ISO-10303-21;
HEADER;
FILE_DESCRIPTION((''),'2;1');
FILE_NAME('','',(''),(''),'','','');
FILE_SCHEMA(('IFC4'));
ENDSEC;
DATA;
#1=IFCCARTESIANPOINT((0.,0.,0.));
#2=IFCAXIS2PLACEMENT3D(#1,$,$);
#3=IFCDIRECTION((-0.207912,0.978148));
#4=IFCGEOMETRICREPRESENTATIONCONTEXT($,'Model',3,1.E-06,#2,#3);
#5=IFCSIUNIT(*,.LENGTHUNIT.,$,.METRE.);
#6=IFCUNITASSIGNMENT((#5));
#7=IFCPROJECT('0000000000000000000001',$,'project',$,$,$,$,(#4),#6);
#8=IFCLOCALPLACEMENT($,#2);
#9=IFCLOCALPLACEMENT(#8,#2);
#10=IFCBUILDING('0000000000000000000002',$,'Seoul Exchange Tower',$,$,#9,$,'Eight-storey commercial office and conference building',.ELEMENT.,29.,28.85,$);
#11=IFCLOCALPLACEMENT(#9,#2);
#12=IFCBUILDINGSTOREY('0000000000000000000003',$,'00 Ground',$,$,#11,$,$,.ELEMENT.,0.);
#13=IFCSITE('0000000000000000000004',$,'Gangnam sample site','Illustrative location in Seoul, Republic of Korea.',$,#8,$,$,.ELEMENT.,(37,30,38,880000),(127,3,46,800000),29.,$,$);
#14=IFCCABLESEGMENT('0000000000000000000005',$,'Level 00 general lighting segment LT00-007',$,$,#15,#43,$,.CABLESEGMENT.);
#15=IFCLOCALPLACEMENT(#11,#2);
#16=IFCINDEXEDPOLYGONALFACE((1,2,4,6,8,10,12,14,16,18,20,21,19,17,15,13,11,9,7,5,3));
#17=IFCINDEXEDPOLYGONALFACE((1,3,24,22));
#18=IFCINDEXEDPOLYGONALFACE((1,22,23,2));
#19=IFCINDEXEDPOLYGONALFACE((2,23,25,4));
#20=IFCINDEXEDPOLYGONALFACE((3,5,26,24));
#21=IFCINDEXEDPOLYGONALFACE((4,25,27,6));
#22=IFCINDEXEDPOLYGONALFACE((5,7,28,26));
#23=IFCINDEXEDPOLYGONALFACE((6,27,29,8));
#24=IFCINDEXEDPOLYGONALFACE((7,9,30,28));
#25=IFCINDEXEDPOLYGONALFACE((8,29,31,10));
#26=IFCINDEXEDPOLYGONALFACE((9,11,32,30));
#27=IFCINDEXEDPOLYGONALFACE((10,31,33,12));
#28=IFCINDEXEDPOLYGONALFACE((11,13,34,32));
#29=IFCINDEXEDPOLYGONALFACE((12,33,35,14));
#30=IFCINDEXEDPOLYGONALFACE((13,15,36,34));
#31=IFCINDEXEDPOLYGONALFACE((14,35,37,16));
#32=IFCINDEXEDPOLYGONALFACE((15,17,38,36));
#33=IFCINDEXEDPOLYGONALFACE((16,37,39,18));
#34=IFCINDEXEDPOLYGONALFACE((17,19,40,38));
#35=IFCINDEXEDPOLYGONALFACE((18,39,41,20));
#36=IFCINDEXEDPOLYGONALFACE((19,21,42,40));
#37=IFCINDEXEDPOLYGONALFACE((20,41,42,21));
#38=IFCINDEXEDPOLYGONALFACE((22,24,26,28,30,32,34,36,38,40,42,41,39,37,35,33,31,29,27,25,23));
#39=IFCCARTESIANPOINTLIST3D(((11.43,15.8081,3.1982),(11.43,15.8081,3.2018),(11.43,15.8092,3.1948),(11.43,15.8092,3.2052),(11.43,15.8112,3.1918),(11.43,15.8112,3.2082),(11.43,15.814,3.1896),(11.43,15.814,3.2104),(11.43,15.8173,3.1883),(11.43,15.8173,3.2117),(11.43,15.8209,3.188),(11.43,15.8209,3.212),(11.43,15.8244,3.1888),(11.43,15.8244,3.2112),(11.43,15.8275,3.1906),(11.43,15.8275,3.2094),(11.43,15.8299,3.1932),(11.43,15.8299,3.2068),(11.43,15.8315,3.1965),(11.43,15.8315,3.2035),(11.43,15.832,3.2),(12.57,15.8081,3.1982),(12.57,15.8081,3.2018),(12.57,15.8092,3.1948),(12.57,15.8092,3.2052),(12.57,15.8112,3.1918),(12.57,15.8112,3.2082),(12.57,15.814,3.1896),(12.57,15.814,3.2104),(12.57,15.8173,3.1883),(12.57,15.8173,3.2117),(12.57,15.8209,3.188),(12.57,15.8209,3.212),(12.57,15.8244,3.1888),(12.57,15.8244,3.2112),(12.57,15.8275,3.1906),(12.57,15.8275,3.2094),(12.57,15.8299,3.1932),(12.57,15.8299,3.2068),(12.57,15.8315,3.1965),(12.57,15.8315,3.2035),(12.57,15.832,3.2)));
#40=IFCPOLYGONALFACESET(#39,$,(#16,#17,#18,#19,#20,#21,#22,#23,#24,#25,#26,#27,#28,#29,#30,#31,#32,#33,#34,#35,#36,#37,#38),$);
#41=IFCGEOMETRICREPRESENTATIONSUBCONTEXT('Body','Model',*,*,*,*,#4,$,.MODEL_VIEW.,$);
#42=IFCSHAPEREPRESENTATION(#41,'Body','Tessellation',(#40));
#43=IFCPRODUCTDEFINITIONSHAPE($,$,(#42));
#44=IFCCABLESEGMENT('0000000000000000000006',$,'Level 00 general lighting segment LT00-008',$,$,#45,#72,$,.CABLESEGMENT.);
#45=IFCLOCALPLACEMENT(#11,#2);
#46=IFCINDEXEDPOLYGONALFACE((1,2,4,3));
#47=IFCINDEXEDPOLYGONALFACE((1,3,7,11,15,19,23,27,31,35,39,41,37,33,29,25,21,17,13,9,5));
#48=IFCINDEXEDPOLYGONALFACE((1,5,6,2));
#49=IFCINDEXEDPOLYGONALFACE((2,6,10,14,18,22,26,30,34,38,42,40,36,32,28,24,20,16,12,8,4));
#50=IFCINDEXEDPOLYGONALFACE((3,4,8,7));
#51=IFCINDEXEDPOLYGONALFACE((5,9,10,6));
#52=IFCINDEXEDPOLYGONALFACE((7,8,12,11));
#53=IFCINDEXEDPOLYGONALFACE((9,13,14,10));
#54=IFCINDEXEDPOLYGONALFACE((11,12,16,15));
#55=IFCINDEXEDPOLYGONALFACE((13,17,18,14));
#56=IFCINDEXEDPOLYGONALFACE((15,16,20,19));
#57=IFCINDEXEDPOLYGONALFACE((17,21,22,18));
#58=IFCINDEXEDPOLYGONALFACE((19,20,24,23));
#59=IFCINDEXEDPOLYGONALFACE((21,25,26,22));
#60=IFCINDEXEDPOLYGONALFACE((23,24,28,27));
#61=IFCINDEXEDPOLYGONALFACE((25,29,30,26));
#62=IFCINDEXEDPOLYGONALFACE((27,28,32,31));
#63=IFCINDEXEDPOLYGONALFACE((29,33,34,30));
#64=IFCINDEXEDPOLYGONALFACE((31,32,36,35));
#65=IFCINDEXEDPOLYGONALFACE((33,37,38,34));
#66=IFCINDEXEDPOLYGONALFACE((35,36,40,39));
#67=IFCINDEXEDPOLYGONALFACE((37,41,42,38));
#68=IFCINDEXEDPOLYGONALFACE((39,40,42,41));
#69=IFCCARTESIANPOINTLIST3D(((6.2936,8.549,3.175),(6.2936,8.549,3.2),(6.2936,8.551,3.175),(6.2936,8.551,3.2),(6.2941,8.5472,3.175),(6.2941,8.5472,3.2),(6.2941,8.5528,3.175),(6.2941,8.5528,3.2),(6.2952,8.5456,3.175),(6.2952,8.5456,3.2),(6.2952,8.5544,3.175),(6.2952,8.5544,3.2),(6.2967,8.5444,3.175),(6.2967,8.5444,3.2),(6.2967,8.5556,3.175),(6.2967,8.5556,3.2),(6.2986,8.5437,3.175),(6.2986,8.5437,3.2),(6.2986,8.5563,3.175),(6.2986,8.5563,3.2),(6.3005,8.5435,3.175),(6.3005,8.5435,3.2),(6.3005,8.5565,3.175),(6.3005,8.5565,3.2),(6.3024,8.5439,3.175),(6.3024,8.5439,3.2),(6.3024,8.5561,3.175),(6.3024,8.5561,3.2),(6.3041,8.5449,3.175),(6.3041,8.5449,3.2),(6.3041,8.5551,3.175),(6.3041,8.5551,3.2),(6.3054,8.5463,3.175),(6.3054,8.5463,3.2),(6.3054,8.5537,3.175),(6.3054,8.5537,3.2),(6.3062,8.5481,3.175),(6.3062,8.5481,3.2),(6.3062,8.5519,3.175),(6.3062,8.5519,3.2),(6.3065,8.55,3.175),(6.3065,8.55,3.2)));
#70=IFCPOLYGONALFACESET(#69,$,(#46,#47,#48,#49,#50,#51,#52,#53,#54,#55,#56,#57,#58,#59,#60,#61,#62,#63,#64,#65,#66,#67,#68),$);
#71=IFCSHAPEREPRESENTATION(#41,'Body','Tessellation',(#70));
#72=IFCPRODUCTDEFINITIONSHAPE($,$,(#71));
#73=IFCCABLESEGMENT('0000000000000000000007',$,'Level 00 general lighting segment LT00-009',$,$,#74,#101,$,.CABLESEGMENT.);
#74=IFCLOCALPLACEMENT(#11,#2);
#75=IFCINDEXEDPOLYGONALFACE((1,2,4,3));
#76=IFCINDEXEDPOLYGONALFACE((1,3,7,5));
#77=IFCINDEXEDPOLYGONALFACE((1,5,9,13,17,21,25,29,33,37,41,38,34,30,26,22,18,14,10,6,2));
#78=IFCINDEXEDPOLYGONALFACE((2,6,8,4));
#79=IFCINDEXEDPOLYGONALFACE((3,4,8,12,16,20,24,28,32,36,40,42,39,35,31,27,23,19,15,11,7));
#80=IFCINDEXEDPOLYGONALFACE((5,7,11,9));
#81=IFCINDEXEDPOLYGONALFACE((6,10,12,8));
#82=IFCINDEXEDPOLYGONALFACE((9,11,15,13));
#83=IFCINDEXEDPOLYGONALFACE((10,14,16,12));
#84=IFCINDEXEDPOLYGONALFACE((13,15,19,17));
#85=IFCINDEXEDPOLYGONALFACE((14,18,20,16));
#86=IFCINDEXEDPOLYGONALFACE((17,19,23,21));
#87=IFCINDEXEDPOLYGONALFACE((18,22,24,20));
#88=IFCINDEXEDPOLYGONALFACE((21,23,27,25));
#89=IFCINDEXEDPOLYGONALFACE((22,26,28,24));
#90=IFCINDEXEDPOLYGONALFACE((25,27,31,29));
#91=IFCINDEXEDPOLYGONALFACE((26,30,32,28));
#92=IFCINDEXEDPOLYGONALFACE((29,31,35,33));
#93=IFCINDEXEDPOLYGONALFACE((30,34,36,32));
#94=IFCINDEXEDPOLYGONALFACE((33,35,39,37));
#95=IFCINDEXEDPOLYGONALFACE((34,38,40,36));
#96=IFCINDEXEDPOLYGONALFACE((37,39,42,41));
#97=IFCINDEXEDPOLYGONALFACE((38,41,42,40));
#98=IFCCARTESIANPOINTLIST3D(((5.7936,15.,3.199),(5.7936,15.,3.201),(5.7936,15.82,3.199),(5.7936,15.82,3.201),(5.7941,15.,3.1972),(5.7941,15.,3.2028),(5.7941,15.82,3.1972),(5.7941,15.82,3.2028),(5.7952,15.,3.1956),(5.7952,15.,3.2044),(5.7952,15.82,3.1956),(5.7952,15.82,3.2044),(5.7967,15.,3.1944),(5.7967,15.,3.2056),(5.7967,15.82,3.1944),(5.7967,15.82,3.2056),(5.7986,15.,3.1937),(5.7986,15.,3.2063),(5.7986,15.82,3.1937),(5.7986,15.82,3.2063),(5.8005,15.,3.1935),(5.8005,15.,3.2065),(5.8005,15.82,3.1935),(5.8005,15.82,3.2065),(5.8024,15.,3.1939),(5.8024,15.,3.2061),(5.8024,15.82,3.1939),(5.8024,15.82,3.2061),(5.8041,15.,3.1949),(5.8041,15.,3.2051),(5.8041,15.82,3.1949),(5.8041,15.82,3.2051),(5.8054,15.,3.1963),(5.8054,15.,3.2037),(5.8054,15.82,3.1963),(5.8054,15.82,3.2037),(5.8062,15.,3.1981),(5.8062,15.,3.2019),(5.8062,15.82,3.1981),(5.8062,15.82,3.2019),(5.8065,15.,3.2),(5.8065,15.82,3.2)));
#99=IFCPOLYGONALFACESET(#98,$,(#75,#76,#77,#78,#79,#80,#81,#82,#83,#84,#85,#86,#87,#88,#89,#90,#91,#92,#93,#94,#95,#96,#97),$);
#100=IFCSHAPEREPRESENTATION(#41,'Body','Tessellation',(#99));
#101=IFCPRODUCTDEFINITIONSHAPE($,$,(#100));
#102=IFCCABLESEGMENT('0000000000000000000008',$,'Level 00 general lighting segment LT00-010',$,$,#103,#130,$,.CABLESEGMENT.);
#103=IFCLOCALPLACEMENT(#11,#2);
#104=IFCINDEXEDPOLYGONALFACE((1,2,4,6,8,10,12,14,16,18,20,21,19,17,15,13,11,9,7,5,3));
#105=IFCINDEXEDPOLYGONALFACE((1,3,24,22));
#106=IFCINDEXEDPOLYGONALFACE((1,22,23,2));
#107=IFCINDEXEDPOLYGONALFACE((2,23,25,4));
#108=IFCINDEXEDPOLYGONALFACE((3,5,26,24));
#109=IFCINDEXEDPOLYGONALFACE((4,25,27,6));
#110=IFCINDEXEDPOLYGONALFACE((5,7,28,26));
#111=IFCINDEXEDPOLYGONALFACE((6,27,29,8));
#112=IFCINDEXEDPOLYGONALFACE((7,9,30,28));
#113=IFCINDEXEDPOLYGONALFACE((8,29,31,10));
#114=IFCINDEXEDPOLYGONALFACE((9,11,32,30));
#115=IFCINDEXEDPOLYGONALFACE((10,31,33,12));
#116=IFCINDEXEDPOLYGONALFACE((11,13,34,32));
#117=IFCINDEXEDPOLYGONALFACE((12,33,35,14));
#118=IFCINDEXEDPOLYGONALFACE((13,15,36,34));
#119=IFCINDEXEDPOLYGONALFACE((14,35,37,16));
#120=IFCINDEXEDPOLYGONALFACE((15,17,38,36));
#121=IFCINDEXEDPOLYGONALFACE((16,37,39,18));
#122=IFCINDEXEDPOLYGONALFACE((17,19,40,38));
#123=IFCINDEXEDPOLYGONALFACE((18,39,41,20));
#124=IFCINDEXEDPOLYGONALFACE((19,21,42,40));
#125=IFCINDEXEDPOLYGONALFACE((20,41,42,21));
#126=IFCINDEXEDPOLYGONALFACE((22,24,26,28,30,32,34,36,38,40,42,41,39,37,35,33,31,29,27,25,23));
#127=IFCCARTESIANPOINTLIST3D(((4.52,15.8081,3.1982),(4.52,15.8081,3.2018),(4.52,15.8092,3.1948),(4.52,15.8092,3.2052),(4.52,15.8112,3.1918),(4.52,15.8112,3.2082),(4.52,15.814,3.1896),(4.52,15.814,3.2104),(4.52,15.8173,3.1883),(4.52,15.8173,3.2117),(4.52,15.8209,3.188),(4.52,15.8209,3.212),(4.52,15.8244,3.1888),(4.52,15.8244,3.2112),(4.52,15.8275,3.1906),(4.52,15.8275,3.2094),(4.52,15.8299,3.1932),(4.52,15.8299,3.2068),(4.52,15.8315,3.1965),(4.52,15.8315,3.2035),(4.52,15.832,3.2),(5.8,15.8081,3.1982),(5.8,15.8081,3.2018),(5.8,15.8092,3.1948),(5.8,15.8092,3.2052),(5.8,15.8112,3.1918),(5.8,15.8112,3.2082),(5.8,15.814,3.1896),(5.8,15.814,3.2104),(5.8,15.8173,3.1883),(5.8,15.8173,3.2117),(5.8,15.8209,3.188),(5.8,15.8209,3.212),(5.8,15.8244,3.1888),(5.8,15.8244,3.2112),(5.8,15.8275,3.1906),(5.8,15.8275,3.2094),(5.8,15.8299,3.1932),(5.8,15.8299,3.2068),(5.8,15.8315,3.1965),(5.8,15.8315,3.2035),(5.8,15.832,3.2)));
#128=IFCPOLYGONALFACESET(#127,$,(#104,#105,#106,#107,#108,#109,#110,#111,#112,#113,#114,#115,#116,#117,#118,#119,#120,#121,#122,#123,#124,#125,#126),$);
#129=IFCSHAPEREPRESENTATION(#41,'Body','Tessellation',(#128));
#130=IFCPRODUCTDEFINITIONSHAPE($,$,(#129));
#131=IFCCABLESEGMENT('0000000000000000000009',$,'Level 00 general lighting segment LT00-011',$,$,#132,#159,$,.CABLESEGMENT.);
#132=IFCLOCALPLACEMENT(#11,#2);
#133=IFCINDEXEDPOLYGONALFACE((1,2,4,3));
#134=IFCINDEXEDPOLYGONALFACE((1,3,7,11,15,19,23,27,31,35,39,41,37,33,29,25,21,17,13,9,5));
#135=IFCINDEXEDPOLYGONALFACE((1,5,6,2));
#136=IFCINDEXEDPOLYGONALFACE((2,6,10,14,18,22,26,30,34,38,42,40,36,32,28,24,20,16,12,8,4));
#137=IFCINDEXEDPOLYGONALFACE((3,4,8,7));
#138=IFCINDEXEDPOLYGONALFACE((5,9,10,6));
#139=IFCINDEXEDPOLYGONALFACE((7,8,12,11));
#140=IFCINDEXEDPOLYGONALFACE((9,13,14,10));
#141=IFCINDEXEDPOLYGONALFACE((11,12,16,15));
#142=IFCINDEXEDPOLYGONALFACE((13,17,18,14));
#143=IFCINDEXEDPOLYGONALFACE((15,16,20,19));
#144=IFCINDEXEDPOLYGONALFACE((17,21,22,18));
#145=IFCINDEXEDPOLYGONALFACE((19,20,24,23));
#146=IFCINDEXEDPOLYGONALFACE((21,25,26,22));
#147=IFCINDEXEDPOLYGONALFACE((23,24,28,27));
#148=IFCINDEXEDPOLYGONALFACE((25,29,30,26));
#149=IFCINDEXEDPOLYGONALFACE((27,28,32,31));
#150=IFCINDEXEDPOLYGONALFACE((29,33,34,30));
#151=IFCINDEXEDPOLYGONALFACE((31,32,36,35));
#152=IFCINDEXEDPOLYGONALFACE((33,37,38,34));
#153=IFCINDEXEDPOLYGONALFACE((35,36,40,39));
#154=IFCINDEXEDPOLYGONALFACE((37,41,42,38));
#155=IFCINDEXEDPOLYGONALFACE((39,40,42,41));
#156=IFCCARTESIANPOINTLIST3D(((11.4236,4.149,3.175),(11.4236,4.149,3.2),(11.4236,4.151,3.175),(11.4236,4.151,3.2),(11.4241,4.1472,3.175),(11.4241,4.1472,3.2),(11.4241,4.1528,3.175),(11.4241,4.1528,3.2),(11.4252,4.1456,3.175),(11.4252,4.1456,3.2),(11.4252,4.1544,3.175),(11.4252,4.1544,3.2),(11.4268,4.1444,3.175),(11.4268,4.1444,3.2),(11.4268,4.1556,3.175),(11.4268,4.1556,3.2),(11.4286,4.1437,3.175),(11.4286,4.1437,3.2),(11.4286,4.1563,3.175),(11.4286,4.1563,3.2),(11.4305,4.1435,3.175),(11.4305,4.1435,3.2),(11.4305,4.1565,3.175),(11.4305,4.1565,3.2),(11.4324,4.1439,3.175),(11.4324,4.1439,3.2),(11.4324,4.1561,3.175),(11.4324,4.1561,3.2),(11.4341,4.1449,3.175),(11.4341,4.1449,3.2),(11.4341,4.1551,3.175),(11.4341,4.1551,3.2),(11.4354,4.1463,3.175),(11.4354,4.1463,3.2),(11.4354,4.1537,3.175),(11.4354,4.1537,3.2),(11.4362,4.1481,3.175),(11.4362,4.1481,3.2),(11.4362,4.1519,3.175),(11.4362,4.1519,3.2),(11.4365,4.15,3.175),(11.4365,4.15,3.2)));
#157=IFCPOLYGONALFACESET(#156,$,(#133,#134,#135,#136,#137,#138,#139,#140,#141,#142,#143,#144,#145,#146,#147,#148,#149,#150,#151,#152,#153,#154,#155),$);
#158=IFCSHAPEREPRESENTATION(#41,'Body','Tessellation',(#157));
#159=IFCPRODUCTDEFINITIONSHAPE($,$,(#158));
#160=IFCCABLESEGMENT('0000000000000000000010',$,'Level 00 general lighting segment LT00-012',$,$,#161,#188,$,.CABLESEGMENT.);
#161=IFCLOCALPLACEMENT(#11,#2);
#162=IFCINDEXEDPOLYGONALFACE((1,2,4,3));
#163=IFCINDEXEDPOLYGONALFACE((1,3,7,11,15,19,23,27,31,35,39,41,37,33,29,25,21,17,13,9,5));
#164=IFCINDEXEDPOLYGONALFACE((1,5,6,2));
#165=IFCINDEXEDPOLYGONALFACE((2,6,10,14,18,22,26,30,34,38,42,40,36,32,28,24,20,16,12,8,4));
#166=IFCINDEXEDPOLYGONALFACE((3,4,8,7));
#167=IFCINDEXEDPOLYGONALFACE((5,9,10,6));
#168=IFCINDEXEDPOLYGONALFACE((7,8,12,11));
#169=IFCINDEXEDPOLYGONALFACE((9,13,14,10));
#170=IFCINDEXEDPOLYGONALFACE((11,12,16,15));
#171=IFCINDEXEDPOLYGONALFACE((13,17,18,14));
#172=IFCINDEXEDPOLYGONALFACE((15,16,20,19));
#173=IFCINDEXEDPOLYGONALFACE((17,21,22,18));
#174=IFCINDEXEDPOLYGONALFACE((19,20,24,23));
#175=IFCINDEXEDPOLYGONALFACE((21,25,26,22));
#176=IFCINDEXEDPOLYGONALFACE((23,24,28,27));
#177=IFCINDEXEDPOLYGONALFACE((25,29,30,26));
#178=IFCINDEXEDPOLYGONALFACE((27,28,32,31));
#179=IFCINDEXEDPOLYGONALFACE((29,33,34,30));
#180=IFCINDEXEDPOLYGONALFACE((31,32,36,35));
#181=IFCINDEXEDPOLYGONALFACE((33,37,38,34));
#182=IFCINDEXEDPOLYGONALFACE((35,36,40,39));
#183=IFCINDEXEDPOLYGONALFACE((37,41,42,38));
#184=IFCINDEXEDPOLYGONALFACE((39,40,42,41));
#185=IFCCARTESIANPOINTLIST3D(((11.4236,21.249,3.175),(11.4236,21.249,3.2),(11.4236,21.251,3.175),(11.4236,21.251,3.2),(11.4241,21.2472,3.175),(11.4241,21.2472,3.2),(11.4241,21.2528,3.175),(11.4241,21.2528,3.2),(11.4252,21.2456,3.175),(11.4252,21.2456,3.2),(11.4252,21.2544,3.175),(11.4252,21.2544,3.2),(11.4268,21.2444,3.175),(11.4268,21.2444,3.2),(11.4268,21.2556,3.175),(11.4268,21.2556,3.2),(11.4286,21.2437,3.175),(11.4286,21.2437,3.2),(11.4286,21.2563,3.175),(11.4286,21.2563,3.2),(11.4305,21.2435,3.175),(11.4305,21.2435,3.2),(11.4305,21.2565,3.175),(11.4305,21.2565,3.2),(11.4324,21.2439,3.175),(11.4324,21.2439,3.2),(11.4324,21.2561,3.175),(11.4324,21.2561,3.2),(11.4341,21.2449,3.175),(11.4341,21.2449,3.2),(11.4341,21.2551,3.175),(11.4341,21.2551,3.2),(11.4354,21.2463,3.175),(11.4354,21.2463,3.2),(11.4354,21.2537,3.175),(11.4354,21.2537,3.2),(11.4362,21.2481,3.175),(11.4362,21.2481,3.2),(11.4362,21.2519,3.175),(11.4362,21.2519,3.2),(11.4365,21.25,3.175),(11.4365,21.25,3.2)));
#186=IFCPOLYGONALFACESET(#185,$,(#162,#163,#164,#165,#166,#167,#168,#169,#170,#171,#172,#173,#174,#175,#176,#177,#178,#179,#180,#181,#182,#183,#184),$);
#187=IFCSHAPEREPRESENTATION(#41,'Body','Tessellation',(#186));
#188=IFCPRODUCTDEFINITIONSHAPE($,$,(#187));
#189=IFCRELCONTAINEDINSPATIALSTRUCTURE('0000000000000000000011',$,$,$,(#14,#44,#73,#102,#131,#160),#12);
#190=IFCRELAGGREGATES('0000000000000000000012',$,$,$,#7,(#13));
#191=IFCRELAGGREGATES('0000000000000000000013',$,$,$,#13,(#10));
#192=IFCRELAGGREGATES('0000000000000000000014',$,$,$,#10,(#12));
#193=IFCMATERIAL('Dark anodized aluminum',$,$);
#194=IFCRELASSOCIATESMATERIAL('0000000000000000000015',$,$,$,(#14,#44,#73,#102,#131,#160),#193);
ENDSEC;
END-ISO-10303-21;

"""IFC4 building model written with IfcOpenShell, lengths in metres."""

from ifc_helpers import new_model, si_unit, direction, frame, origin, place, context, subcontext, project, spatial, circle, extrude, material, element, save


model = new_model("IFC4")

# Units and contexts
model_context = context("Model", 3, precision=1e-06, world=origin(), true_north=direction((-0.207912, 0.978148)))
body_context = subcontext(model_context, "Body", "Model", "MODEL_VIEW")
ifc_project = project(units=[si_unit("LENGTHUNIT", "METRE")], contexts=[model_context])

# Site, building, storey
site_placement = place(None, origin())
site = spatial("IfcSite", under=ifc_project, at=site_placement, Name="Gangnam sample site", Description="Illustrative location in Seoul, Republic of Korea.", CompositionType="ELEMENT", RefLatitude=(37, 30, 38, 880000), RefLongitude=(127, 3, 46, 800000), RefElevation=29.0)
building_placement = place(site_placement, origin())
building = spatial("IfcBuilding", under=site, at=building_placement, Name="Seoul Exchange Tower", LongName="Eight-storey commercial office and conference building", CompositionType="ELEMENT", ElevationOfRefHeight=29.0, ElevationOfTerrain=28.85)
storey_placement = place(building_placement, origin())
storey = spatial("IfcBuildingStorey", under=building, at=storey_placement, Name="00 Ground", CompositionType="ELEMENT", Elevation=0.0)

# Shared definitions
ifc_material = material(Name="Dark anodized aluminum")
placement = place(storey_placement, origin())

# Cable segments
element("IfcCableSegment", 1, at=placement, inside=storey, material=ifc_material, Name="Level 00 general lighting segment LT00-007", PredefinedType="CABLESEGMENT", context=body_context, shape_type="SweptSolid", body=[
    extrude(circle(Radius=0.012), frame((11.43, 15.82, 3.2), z_axis=(1.0, 0.0, 0.0), x_axis=(0.0, 1.0, 0.0)), (0.0, 0.0, 1.0), 1.14),
])
element("IfcCableSegment", 2, at=placement, inside=storey, material=ifc_material, Name="Level 00 general lighting segment LT00-008", PredefinedType="CABLESEGMENT", context=body_context, shape_type="SweptSolid", body=[
    extrude(circle(Radius=0.0065), frame((6.3, 8.55, 3.2), z_axis=(0.0, 0.0, -1.0), x_axis=(1.0, 0.0, 0.0)), (0.0, 0.0, 1.0), 0.025),
])
element("IfcCableSegment", 3, at=placement, inside=storey, material=ifc_material, Name="Level 00 general lighting segment LT00-009", PredefinedType="CABLESEGMENT", context=body_context, shape_type="SweptSolid", body=[
    extrude(circle(Radius=0.0065), frame((5.8, 15.82, 3.2), z_axis=(0.0, -1.0, 0.0), x_axis=(1.0, 0.0, 0.0)), (0.0, 0.0, 1.0), 0.82),
])
element("IfcCableSegment", 4, at=placement, inside=storey, material=ifc_material, Name="Level 00 general lighting segment LT00-010", PredefinedType="CABLESEGMENT", context=body_context, shape_type="SweptSolid", body=[
    extrude(circle(Radius=0.012), frame((5.8, 15.82, 3.2), z_axis=(-1.0, 0.0, 0.0), x_axis=(0.0, 1.0, 0.0)), (0.0, 0.0, 1.0), 1.28),
])
element("IfcCableSegment", 5, at=placement, inside=storey, material=ifc_material, Name="Level 00 general lighting segment LT00-011", PredefinedType="CABLESEGMENT", context=body_context, shape_type="SweptSolid", body=[
    extrude(circle(Radius=0.0065), frame((11.43, 4.15, 3.2), z_axis=(0.0, 0.0, -1.0), x_axis=(1.0, 0.0, 0.0)), (0.0, 0.0, 1.0), 0.025),
])
element("IfcCableSegment", 6, at=placement, inside=storey, material=ifc_material, Name="Level 00 general lighting segment LT00-012", PredefinedType="CABLESEGMENT", context=body_context, shape_type="SweptSolid", body=[
    extrude(circle(Radius=0.0065), frame((11.43, 21.25, 3.2), z_axis=(0.0, 0.0, -1.0), x_axis=(1.0, 0.0, 0.0)), (0.0, 0.0, 1.0), 0.025),
])

save(model, "model.ifc")
